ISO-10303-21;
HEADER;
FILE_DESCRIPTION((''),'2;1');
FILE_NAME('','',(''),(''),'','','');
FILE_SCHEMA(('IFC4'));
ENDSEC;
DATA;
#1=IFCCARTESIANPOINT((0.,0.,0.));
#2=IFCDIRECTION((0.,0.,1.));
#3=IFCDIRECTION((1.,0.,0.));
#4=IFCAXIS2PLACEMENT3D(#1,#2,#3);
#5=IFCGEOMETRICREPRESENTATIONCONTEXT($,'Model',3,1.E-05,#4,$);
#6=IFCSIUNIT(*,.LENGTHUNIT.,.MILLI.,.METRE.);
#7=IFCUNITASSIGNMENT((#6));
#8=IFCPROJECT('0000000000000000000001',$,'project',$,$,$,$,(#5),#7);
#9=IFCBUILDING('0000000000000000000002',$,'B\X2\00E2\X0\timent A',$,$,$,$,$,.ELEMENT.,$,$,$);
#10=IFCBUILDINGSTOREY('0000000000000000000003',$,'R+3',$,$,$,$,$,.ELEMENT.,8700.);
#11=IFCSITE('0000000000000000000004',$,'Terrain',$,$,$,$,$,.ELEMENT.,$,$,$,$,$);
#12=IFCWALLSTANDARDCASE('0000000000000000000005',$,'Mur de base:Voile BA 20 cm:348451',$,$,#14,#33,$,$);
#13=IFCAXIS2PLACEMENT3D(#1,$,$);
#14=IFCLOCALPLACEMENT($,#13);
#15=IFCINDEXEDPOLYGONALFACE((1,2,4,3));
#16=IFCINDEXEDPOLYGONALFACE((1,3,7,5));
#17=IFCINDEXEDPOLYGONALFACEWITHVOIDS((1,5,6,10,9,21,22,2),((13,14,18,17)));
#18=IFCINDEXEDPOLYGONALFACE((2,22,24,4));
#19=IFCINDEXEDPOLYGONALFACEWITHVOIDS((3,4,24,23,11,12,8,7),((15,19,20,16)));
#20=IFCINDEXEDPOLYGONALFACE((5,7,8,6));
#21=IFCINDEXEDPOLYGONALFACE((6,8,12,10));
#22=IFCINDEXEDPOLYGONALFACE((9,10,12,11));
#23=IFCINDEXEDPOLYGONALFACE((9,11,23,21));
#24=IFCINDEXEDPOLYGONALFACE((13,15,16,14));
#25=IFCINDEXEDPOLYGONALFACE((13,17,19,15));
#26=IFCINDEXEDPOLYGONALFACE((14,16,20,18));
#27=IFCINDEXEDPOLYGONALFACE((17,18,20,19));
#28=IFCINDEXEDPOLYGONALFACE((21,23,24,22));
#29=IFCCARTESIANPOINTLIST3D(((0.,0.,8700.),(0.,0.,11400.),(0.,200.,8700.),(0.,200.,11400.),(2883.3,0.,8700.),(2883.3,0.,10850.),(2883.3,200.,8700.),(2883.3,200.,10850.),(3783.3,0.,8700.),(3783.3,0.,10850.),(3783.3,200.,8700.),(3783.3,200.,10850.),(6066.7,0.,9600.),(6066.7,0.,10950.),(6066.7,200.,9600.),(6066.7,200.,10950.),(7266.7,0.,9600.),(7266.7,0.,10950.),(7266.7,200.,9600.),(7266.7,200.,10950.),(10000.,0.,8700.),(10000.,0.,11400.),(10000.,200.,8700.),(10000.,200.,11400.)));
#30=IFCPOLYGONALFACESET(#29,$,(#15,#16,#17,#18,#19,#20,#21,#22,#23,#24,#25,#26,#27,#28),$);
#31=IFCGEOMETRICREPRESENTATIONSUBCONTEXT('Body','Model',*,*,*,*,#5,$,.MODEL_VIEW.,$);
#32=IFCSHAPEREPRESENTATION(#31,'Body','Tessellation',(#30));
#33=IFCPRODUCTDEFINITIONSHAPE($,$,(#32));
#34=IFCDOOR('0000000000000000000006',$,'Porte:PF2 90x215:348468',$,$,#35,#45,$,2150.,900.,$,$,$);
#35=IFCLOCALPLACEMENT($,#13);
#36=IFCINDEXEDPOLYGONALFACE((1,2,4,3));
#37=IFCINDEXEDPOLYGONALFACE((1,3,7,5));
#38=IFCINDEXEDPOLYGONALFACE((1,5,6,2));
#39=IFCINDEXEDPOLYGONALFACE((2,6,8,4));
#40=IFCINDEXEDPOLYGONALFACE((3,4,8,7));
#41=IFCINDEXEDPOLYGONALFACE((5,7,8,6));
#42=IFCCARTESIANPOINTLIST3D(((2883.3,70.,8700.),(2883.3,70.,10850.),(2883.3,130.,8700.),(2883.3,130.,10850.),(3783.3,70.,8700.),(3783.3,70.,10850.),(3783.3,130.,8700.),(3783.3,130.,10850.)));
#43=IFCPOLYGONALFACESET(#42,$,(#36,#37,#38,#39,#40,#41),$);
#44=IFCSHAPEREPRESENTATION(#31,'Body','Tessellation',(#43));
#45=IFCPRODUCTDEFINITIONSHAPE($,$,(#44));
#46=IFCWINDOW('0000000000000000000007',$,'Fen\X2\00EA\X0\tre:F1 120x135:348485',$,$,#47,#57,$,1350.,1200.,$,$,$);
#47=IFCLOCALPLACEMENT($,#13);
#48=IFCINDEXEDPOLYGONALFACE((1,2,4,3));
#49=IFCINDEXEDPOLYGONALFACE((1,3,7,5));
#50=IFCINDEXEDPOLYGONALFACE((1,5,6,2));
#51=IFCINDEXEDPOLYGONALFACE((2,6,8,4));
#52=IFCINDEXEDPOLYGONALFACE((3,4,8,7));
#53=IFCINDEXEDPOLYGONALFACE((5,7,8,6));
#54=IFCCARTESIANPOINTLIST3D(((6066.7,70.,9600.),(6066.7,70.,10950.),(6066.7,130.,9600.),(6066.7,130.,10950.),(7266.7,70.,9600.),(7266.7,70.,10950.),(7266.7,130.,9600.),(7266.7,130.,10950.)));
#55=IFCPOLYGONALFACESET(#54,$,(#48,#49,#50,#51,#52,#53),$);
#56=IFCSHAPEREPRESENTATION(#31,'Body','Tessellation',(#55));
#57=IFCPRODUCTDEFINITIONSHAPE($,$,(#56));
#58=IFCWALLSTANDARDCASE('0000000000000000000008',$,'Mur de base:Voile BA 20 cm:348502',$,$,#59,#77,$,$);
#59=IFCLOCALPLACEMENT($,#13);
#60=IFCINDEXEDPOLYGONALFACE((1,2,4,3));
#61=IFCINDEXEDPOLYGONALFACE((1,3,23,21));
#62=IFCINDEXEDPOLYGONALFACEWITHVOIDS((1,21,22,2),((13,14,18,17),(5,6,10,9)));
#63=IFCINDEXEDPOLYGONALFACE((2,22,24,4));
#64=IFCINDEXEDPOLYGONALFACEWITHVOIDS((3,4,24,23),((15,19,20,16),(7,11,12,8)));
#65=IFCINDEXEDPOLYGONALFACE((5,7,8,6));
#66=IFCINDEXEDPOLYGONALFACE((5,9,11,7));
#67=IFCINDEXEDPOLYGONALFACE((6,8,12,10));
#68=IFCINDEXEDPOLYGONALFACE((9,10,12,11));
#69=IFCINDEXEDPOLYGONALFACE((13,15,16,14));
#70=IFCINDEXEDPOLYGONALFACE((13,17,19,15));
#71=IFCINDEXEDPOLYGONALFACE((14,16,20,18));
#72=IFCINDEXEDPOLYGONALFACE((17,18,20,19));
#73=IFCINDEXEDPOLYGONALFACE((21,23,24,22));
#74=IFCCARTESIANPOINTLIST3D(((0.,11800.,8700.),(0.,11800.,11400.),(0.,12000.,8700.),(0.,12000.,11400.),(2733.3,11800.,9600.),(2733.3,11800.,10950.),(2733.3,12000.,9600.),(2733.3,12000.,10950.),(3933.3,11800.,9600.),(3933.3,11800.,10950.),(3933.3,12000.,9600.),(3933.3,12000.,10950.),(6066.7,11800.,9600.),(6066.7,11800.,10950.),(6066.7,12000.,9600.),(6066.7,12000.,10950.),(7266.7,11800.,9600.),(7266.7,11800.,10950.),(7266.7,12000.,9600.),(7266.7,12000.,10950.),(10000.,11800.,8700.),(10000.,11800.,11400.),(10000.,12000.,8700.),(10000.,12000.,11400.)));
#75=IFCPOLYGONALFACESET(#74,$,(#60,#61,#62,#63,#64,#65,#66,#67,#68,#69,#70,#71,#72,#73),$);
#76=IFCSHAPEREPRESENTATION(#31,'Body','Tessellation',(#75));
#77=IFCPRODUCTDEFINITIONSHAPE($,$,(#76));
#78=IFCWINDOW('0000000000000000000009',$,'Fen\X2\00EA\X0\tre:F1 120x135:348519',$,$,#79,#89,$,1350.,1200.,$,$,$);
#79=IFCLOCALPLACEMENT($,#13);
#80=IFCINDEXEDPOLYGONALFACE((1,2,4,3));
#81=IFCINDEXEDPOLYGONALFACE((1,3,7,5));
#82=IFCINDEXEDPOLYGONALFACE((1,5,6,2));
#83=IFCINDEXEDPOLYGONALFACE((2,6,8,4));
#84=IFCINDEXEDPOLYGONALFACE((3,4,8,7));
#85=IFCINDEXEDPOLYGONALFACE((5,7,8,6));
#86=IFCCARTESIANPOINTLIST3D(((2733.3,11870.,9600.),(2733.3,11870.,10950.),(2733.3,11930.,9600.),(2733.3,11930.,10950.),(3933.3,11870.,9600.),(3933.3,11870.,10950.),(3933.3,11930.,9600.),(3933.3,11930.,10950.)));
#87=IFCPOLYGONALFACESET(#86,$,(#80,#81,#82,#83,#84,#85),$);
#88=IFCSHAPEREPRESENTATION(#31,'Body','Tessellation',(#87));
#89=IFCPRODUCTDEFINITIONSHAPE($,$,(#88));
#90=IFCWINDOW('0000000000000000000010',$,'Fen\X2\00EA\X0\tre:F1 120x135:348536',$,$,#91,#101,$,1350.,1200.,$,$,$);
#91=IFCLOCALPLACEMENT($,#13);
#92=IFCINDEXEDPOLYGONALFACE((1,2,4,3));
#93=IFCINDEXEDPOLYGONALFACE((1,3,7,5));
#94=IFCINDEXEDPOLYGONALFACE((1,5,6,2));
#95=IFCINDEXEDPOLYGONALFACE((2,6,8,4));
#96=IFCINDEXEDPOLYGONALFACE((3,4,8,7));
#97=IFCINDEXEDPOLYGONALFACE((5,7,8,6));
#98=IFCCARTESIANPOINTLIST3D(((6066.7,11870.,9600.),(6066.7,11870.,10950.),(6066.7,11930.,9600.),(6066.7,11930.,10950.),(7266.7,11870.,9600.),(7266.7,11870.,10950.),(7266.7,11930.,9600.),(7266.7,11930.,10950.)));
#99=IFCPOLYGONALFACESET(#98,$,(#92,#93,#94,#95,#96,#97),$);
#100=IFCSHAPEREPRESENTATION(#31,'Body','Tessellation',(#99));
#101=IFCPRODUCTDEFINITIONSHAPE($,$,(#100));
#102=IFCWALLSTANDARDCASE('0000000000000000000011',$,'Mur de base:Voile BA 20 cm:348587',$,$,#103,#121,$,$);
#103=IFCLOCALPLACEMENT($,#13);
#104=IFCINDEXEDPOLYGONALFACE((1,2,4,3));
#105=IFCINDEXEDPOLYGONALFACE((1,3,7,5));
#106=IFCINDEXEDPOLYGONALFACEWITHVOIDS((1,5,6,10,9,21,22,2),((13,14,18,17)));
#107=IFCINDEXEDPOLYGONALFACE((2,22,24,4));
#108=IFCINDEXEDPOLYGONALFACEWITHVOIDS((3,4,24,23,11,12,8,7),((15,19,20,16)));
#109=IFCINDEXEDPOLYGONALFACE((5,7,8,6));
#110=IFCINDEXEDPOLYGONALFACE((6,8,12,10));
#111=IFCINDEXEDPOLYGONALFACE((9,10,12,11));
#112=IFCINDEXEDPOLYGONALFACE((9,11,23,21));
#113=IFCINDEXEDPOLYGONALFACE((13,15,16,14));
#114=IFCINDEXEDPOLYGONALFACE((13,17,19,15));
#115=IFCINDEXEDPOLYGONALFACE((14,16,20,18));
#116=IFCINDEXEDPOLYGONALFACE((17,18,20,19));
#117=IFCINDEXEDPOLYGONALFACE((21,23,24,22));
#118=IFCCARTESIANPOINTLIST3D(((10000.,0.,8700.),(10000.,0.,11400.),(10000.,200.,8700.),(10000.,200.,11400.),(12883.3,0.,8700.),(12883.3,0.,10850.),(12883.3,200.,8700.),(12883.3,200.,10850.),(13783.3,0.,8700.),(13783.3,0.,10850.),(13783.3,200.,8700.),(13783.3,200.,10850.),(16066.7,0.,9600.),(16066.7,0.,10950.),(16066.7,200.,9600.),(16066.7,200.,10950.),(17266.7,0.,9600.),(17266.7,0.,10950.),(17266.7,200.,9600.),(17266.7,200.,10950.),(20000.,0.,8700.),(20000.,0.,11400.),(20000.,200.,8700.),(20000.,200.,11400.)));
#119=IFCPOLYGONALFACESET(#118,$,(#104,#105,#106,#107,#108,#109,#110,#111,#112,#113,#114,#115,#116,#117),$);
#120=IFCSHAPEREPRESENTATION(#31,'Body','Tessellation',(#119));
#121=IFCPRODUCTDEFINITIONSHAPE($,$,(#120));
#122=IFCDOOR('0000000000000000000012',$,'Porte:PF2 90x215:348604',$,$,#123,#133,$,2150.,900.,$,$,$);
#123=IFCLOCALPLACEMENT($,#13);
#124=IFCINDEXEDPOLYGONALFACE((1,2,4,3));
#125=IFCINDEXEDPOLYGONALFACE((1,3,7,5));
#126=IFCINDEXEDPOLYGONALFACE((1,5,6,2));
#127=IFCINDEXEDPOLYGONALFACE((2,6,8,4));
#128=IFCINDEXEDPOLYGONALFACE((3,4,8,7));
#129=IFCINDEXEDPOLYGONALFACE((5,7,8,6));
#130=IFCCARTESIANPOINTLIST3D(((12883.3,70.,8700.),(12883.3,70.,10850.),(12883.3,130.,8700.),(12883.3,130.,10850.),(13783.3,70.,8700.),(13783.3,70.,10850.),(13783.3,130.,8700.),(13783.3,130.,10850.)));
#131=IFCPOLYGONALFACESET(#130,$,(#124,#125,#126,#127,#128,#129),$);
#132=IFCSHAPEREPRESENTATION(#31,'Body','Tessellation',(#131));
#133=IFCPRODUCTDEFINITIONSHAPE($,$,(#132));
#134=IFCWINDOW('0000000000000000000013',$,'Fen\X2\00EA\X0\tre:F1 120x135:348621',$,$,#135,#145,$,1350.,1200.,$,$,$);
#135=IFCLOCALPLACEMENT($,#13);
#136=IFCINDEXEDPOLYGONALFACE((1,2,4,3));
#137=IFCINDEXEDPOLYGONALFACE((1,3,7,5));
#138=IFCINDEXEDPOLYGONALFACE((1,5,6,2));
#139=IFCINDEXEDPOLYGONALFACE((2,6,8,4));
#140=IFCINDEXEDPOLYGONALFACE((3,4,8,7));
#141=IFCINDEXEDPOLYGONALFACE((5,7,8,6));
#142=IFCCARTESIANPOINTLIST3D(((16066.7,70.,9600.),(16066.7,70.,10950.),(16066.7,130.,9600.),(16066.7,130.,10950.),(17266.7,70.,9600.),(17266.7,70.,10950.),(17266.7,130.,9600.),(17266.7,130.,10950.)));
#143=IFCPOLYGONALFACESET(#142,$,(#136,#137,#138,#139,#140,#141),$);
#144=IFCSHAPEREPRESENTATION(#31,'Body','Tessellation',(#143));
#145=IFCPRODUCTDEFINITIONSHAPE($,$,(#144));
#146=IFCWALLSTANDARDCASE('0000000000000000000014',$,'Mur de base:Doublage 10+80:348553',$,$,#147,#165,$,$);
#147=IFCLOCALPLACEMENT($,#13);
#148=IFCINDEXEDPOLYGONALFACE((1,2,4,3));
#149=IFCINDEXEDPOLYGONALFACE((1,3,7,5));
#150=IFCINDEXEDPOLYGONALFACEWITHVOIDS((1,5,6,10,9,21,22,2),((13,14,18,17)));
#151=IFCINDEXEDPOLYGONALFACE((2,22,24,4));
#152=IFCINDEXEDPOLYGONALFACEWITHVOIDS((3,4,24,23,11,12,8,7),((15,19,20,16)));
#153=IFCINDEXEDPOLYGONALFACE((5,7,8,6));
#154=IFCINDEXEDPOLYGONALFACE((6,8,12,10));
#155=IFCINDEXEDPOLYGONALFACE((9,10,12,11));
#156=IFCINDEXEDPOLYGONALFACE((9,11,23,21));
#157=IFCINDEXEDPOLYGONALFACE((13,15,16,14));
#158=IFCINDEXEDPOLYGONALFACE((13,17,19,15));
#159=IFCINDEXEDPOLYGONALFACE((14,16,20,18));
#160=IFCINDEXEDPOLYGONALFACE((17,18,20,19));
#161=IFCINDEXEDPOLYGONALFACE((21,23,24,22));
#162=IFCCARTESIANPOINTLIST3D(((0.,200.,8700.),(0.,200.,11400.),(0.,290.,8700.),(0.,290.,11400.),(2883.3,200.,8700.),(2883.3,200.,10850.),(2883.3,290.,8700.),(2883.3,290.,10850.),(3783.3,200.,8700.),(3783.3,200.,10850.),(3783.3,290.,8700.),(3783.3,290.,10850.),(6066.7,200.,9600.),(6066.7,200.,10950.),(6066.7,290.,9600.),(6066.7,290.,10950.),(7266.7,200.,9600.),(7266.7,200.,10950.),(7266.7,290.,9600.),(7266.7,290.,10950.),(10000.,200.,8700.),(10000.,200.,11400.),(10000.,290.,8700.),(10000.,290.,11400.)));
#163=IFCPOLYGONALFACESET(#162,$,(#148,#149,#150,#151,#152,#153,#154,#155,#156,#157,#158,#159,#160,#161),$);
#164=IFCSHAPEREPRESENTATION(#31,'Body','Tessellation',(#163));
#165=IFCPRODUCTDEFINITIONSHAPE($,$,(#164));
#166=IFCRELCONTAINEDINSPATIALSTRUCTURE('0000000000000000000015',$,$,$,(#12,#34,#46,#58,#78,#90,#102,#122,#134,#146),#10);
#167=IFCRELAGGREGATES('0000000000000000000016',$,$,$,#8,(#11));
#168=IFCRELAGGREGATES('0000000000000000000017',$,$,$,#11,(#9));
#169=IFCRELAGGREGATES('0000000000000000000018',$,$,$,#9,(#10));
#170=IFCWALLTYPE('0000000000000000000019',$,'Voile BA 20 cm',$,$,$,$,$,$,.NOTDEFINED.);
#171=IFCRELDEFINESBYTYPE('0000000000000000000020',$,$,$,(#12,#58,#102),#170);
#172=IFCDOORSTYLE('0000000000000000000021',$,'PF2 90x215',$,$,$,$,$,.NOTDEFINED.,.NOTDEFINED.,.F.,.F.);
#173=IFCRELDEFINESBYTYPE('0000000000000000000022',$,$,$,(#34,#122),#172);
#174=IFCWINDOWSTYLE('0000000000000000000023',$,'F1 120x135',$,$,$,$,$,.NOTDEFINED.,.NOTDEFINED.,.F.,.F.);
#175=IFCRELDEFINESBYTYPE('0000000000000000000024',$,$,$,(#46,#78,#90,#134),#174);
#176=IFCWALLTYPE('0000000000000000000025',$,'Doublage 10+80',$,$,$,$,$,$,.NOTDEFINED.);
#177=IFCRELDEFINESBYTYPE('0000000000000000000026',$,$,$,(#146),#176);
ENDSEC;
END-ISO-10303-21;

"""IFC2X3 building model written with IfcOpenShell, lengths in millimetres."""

from ifc_helpers import new_model, si_unit, frame, frame_2d, origin_with_axes, place, context, subcontext, project, spatial, rectangle, extrude, type_object, element, fill, save


model = new_model("IFC2X3")

# Units and contexts
model_context = context("Model", 3, precision=1e-05, world=origin_with_axes())
body_context = subcontext(model_context, "Body", "Model", "MODEL_VIEW")
ifc_project = project(units=[si_unit("LENGTHUNIT", "METRE", prefix="MILLI")], contexts=[model_context])

# Site, building, storey
site = spatial("IfcSite", under=ifc_project, Name="Terrain", CompositionType="ELEMENT")
building = spatial("IfcBuilding", under=site, Name="Bâtiment A", CompositionType="ELEMENT")
storey = spatial("IfcBuildingStorey", under=building, Name="R+3", CompositionType="ELEMENT", Elevation=8700.0)

# Wall, openings, door, window
wall_type_1 = type_object("IfcWallType", Name="Voile BA 20 cm", PredefinedType="NOTDEFINED")
wall_1_placement = place(None, origin_with_axes())
wall_1 = element("IfcWallStandardCase", 1, at=wall_1_placement, inside=storey, type_object=wall_type_1, Name="Mur de base:Voile BA 20 cm:348451", context=body_context, shape_type="SweptSolid", body=[
    extrude(rectangle(XDim=10000.0, YDim=200.0, at=frame_2d((5000.0, 100.0))), frame((0.0, 0.0, 8700.0), z_axis=(0.0, 0.0, 1.0), x_axis=(1.0, 0.0, 0.0)), (0.0, 0.0, 1.0), 2700.0),
])
opening_1_placement = place(None, origin_with_axes())
opening_1 = element("IfcOpeningElement", 2, at=opening_1_placement, cuts=wall_1, context=body_context, shape_type="SweptSolid", body=[
    extrude(rectangle(XDim=900.0, YDim=320.0, at=frame_2d((3333.3, 100.0))), frame((0.0, 0.0, 8700.0), z_axis=(0.0, 0.0, 1.0), x_axis=(1.0, 0.0, 0.0)), (0.0, 0.0, 1.0), 2150.0),
])
opening_2_placement = place(None, origin_with_axes())
opening_2 = element("IfcOpeningElement", 3, at=opening_2_placement, cuts=wall_1, context=body_context, shape_type="SweptSolid", body=[
    extrude(rectangle(XDim=1200.0, YDim=320.0, at=frame_2d((6666.7, 100.0))), frame((0.0, 0.0, 9600.0), z_axis=(0.0, 0.0, 1.0), x_axis=(1.0, 0.0, 0.0)), (0.0, 0.0, 1.0), 1350.0),
])
door_style = type_object("IfcDoorStyle", Name="PF2 90x215", ConstructionType="NOTDEFINED", OperationType="NOTDEFINED", ParameterTakesPrecedence=False, Sizeable=False)
door_1_placement = place(None, origin_with_axes())
door_1 = element("IfcDoor", 4, at=door_1_placement, inside=storey, type_object=door_style, Name="Porte:PF2 90x215:348468", OverallHeight=2150.0, OverallWidth=900.0, context=body_context, shape_type="SweptSolid", body=[
    extrude(rectangle(XDim=900.0, YDim=60.0, at=frame_2d((3333.3, 100.0))), frame((0.0, 0.0, 8700.0), z_axis=(0.0, 0.0, 1.0), x_axis=(1.0, 0.0, 0.0)), (0.0, 0.0, 1.0), 2150.0),
])
fill(opening_1, door_1)
window_style = type_object("IfcWindowStyle", Name="F1 120x135", ConstructionType="NOTDEFINED", OperationType="NOTDEFINED", ParameterTakesPrecedence=False, Sizeable=False)
window_1_placement = place(None, origin_with_axes())
window_1 = element("IfcWindow", 5, at=window_1_placement, inside=storey, type_object=window_style, Name="Fenêtre:F1 120x135:348485", OverallHeight=1350.0, OverallWidth=1200.0, context=body_context, shape_type="SweptSolid", body=[
    extrude(rectangle(XDim=1200.0, YDim=60.0, at=frame_2d((6666.7, 100.0))), frame((0.0, 0.0, 9600.0), z_axis=(0.0, 0.0, 1.0), x_axis=(1.0, 0.0, 0.0)), (0.0, 0.0, 1.0), 1350.0),
])
fill(opening_2, window_1)

# Wall, openings, windows
wall_2_placement = place(None, origin_with_axes())
wall_2 = element("IfcWallStandardCase", 6, at=wall_2_placement, inside=storey, type_object=wall_type_1, Name="Mur de base:Voile BA 20 cm:348502", context=body_context, shape_type="SweptSolid", body=[
    extrude(rectangle(XDim=10000.0, YDim=200.0, at=frame_2d((5000.0, 11900.0))), frame((0.0, 0.0, 8700.0), z_axis=(0.0, 0.0, 1.0), x_axis=(1.0, 0.0, 0.0)), (0.0, 0.0, 1.0), 2700.0),
])
opening_3_placement = place(None, origin_with_axes())
opening_3 = element("IfcOpeningElement", 7, at=opening_3_placement, cuts=wall_2, context=body_context, shape_type="SweptSolid", body=[
    extrude(rectangle(XDim=1200.0, YDim=320.0, at=frame_2d((3333.3, 11900.0))), frame((0.0, 0.0, 9600.0), z_axis=(0.0, 0.0, 1.0), x_axis=(1.0, 0.0, 0.0)), (0.0, 0.0, 1.0), 1350.0),
])
opening_4_placement = place(None, origin_with_axes())
opening_4 = element("IfcOpeningElement", 8, at=opening_4_placement, cuts=wall_2, context=body_context, shape_type="SweptSolid", body=[
    extrude(rectangle(XDim=1200.0, YDim=320.0, at=frame_2d((6666.7, 11900.0))), frame((0.0, 0.0, 9600.0), z_axis=(0.0, 0.0, 1.0), x_axis=(1.0, 0.0, 0.0)), (0.0, 0.0, 1.0), 1350.0),
])
window_2_placement = place(None, origin_with_axes())
window_2 = element("IfcWindow", 9, at=window_2_placement, inside=storey, type_object=window_style, Name="Fenêtre:F1 120x135:348519", OverallHeight=1350.0, OverallWidth=1200.0, context=body_context, shape_type="SweptSolid", body=[
    extrude(rectangle(XDim=1200.0, YDim=60.0, at=frame_2d((3333.3, 11900.0))), frame((0.0, 0.0, 9600.0), z_axis=(0.0, 0.0, 1.0), x_axis=(1.0, 0.0, 0.0)), (0.0, 0.0, 1.0), 1350.0),
])
fill(opening_3, window_2)
window_3_placement = place(None, origin_with_axes())
window_3 = element("IfcWindow", 10, at=window_3_placement, inside=storey, type_object=window_style, Name="Fenêtre:F1 120x135:348536", OverallHeight=1350.0, OverallWidth=1200.0, context=body_context, shape_type="SweptSolid", body=[
    extrude(rectangle(XDim=1200.0, YDim=60.0, at=frame_2d((6666.7, 11900.0))), frame((0.0, 0.0, 9600.0), z_axis=(0.0, 0.0, 1.0), x_axis=(1.0, 0.0, 0.0)), (0.0, 0.0, 1.0), 1350.0),
])
fill(opening_4, window_3)

# Wall, openings, door, window
wall_3_placement = place(None, origin_with_axes())
wall_3 = element("IfcWallStandardCase", 11, at=wall_3_placement, inside=storey, type_object=wall_type_1, Name="Mur de base:Voile BA 20 cm:348587", context=body_context, shape_type="SweptSolid", body=[
    extrude(rectangle(XDim=10000.0, YDim=200.0, at=frame_2d((15000.0, 100.0))), frame((0.0, 0.0, 8700.0), z_axis=(0.0, 0.0, 1.0), x_axis=(1.0, 0.0, 0.0)), (0.0, 0.0, 1.0), 2700.0),
])
opening_5_placement = place(None, origin_with_axes())
opening_5 = element("IfcOpeningElement", 12, at=opening_5_placement, cuts=wall_3, context=body_context, shape_type="SweptSolid", body=[
    extrude(rectangle(XDim=900.0, YDim=320.0, at=frame_2d((13333.3, 100.0))), frame((0.0, 0.0, 8700.0), z_axis=(0.0, 0.0, 1.0), x_axis=(1.0, 0.0, 0.0)), (0.0, 0.0, 1.0), 2150.0),
])
opening_6_placement = place(None, origin_with_axes())
opening_6 = element("IfcOpeningElement", 13, at=opening_6_placement, cuts=wall_3, context=body_context, shape_type="SweptSolid", body=[
    extrude(rectangle(XDim=1200.0, YDim=320.0, at=frame_2d((16666.7, 100.0))), frame((0.0, 0.0, 9600.0), z_axis=(0.0, 0.0, 1.0), x_axis=(1.0, 0.0, 0.0)), (0.0, 0.0, 1.0), 1350.0),
])
door_2_placement = place(None, origin_with_axes())
door_2 = element("IfcDoor", 14, at=door_2_placement, inside=storey, type_object=door_style, Name="Porte:PF2 90x215:348604", OverallHeight=2150.0, OverallWidth=900.0, context=body_context, shape_type="SweptSolid", body=[
    extrude(rectangle(XDim=900.0, YDim=60.0, at=frame_2d((13333.3, 100.0))), frame((0.0, 0.0, 8700.0), z_axis=(0.0, 0.0, 1.0), x_axis=(1.0, 0.0, 0.0)), (0.0, 0.0, 1.0), 2150.0),
])
fill(opening_5, door_2)
window_4_placement = place(None, origin_with_axes())
window_4 = element("IfcWindow", 15, at=window_4_placement, inside=storey, type_object=window_style, Name="Fenêtre:F1 120x135:348621", OverallHeight=1350.0, OverallWidth=1200.0, context=body_context, shape_type="SweptSolid", body=[
    extrude(rectangle(XDim=1200.0, YDim=60.0, at=frame_2d((16666.7, 100.0))), frame((0.0, 0.0, 9600.0), z_axis=(0.0, 0.0, 1.0), x_axis=(1.0, 0.0, 0.0)), (0.0, 0.0, 1.0), 1350.0),
])
fill(opening_6, window_4)

# Wall, openings
wall_type_2 = type_object("IfcWallType", Name="Doublage 10+80", PredefinedType="NOTDEFINED")
wall_4_placement = place(None, origin_with_axes())
wall_4 = element("IfcWallStandardCase", 16, at=wall_4_placement, inside=storey, type_object=wall_type_2, Name="Mur de base:Doublage 10+80:348553", context=body_context, shape_type="SweptSolid", body=[
    extrude(rectangle(XDim=10000.0, YDim=90.0, at=frame_2d((5000.0, 245.0))), frame((0.0, 0.0, 8700.0), z_axis=(0.0, 0.0, 1.0), x_axis=(1.0, 0.0, 0.0)), (0.0, 0.0, 1.0), 2700.0),
])
opening_7_placement = place(None, origin_with_axes())
element("IfcOpeningElement", 17, at=opening_7_placement, cuts=wall_4, context=body_context, shape_type="SweptSolid", body=[
    extrude(rectangle(XDim=900.0, YDim=210.0, at=frame_2d((3333.3, 245.0))), frame((0.0, 0.0, 8700.0), z_axis=(0.0, 0.0, 1.0), x_axis=(1.0, 0.0, 0.0)), (0.0, 0.0, 1.0), 2150.0),
])
opening_8_placement = place(None, origin_with_axes())
element("IfcOpeningElement", 18, at=opening_8_placement, cuts=wall_4, context=body_context, shape_type="SweptSolid", body=[
    extrude(rectangle(XDim=1200.0, YDim=210.0, at=frame_2d((6666.7, 245.0))), frame((0.0, 0.0, 9600.0), z_axis=(0.0, 0.0, 1.0), x_axis=(1.0, 0.0, 0.0)), (0.0, 0.0, 1.0), 1350.0),
])

save(model, "model.ifc")
